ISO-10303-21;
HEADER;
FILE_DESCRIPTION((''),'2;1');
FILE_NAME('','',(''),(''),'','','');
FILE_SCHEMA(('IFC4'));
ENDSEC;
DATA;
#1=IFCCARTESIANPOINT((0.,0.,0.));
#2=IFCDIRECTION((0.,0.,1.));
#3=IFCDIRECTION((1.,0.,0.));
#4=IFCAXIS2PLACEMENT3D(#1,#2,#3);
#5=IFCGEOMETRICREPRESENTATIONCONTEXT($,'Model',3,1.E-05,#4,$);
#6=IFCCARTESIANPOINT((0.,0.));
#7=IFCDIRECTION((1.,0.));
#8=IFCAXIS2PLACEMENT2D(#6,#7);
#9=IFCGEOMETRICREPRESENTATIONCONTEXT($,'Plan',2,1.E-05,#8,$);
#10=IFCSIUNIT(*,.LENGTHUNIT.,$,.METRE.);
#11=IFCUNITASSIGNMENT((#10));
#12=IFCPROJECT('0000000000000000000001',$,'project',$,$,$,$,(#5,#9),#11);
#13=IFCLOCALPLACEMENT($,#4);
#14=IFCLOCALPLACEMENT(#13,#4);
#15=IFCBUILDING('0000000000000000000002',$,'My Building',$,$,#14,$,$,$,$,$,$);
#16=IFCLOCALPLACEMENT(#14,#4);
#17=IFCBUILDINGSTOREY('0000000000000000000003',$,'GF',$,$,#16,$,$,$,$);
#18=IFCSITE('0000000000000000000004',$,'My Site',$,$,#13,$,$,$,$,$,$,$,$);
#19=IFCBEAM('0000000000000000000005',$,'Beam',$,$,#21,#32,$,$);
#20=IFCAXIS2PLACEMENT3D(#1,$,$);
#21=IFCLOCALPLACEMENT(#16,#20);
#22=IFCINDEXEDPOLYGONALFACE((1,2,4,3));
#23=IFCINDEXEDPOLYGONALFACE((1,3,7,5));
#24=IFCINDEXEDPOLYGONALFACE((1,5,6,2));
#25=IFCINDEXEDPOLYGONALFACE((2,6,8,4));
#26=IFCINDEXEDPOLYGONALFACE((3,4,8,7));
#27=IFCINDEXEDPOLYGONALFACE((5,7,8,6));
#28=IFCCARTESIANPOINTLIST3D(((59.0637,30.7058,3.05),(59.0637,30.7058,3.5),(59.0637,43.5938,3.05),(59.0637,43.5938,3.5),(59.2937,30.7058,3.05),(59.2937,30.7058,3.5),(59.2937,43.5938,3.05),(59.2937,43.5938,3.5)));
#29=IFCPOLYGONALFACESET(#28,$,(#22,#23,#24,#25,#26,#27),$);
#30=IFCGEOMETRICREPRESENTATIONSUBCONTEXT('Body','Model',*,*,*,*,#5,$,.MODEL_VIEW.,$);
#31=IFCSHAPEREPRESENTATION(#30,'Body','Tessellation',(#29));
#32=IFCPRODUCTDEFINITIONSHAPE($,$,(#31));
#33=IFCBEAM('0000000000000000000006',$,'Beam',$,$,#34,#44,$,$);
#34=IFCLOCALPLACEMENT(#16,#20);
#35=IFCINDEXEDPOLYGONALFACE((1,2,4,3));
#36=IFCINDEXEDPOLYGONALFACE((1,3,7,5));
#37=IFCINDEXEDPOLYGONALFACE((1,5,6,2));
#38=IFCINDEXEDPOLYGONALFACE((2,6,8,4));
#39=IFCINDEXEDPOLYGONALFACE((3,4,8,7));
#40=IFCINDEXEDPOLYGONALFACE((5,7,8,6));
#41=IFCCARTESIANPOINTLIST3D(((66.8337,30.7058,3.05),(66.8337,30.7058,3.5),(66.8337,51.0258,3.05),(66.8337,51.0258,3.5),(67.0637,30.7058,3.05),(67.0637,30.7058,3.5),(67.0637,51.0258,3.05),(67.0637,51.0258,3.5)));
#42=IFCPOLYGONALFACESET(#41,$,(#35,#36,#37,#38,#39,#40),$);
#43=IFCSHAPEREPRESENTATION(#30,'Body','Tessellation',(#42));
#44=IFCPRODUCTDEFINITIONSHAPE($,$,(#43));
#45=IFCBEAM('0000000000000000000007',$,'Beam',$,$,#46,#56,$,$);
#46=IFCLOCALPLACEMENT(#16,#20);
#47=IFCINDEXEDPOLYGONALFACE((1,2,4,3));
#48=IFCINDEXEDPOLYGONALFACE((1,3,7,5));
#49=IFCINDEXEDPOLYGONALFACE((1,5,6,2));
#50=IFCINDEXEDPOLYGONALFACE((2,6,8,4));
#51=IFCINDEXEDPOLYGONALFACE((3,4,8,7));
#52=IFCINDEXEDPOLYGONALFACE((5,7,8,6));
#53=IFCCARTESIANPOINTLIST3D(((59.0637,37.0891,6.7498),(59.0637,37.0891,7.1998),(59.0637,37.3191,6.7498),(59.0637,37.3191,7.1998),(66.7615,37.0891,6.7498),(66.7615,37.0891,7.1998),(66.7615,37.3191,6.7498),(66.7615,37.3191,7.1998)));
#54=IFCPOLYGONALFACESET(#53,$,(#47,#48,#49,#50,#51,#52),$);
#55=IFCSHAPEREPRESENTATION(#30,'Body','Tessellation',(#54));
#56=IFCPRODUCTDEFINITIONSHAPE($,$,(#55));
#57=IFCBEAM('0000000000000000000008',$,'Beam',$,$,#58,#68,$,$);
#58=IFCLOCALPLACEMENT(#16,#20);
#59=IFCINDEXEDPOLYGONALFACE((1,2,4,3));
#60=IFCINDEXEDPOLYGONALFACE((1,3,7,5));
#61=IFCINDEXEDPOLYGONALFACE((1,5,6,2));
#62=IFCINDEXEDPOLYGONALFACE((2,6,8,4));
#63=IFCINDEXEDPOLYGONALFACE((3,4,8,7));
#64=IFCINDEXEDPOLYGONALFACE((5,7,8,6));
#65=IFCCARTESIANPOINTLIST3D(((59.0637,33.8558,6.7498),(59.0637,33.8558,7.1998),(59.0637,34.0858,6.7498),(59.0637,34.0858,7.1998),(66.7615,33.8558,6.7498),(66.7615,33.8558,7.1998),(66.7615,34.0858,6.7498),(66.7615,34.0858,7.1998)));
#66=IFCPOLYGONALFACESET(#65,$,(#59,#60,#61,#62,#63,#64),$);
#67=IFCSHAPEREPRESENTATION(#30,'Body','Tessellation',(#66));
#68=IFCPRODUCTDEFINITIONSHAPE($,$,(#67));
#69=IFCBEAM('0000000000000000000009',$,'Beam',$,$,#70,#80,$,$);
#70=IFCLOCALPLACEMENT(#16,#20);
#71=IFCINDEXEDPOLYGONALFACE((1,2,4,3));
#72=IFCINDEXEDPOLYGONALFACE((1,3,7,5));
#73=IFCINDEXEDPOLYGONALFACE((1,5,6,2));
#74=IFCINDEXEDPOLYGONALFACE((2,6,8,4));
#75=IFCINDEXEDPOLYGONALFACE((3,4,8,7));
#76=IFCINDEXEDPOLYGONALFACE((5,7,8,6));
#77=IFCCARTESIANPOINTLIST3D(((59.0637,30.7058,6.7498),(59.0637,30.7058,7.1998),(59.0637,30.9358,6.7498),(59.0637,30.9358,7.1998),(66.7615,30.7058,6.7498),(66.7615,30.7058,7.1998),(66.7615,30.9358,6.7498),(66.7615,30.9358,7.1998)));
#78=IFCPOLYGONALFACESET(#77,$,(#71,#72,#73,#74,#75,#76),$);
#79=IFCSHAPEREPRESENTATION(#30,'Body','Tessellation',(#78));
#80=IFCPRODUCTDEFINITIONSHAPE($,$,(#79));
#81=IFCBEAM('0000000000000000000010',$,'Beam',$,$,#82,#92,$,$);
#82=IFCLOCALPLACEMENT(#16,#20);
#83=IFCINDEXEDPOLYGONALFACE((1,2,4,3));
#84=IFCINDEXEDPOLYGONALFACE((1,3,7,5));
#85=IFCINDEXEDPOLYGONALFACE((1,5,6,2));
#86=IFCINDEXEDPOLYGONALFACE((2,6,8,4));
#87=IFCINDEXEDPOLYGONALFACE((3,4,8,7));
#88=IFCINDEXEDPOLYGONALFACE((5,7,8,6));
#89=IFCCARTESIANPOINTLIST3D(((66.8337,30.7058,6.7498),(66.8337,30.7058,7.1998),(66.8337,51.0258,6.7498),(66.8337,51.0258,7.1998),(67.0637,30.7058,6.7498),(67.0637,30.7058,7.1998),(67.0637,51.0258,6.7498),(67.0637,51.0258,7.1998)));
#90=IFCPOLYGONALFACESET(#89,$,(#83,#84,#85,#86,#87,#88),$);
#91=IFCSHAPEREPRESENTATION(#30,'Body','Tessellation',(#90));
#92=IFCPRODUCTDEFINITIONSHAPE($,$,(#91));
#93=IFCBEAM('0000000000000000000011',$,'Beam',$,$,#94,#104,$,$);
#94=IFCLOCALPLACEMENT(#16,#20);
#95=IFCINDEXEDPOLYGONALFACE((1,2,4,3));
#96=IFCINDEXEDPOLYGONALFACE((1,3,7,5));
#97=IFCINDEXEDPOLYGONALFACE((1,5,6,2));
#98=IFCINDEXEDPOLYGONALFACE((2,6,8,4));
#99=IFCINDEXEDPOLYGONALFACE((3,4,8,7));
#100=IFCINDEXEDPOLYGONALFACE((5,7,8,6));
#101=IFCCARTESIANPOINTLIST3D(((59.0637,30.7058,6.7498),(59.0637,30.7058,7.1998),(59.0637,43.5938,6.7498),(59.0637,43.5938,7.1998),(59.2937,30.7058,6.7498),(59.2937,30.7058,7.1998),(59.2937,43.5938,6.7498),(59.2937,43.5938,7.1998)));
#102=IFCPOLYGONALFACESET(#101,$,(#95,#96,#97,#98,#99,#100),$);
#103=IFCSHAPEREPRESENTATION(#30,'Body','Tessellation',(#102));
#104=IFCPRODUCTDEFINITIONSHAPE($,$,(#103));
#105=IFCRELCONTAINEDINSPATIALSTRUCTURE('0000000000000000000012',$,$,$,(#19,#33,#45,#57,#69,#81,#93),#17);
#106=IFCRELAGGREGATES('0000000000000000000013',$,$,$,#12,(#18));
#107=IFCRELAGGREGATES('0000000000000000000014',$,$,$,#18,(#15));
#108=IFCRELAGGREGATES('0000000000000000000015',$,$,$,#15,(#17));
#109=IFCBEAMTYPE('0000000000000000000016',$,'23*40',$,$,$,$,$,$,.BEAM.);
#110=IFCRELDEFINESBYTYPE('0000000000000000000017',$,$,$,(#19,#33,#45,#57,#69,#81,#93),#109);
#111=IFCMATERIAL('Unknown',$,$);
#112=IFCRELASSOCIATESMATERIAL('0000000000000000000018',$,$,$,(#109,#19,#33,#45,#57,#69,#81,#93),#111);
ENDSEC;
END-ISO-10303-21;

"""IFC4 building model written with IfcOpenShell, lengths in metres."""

from ifc_helpers import new_model, si_unit, frame, origin_with_axes, origin_2d_with_axis, place, context, subcontext, project, spatial, rectangle, extrude, material, material_profile, profile_set, profile_usage, type_object, element, save


model = new_model("IFC4")

# Units and contexts
model_context = context("Model", 3, precision=1e-05, world=origin_with_axes())
plan_context = context("Plan", 2, precision=1e-05, world=origin_2d_with_axis())
body_context = subcontext(model_context, "Body", "Model", "MODEL_VIEW")
ifc_project = project(units=[si_unit("LENGTHUNIT", "METRE")], contexts=[model_context, plan_context])

# Site, building, storey
site_placement = place(None, origin_with_axes())
site = spatial("IfcSite", under=ifc_project, at=site_placement, Name="My Site")
building_placement = place(site_placement, origin_with_axes())
building = spatial("IfcBuilding", under=site, at=building_placement, Name="My Building")
storey_placement = place(building_placement, origin_with_axes())
storey = spatial("IfcBuildingStorey", under=building, at=storey_placement, Name="GF")

# Shared definitions
ifc_material = material(Name="Unknown")

# Beams
ifc_material_profile_1 = material_profile(ifc_material, rectangle(XDim=0.23, YDim=0.45))
ifc_profile_set_1 = profile_set([ifc_material_profile_1])
beam_type = type_object("IfcBeamType", Name="23*40", PredefinedType="BEAM", material=ifc_profile_set_1)
ifc_profile_usage_1 = profile_usage(ifc_profile_set_1, cardinal=5)
beam_1_placement = place(storey_placement, frame((59.1787, 30.7058, 3.275), z_axis=(0.0, 1.0, 0.0), x_axis=(-1.0, 0.0, 0.0)))
element("IfcBeam", 1, at=beam_1_placement, inside=storey, type_object=beam_type, material=ifc_profile_usage_1, Name="Beam", context=body_context, shape_type="SweptSolid", body=[
    extrude(rectangle(XDim=0.23, YDim=0.45), origin_with_axes(), (0.0, 0.0, 1.0), 12.888),
])
ifc_profile_usage_2 = profile_usage(ifc_profile_set_1, cardinal=5)
beam_2_placement = place(storey_placement, frame((66.9487, 30.7058, 3.275), z_axis=(0.0, 1.0, 0.0), x_axis=(-1.0, 0.0, 0.0)))
element("IfcBeam", 2, at=beam_2_placement, inside=storey, type_object=beam_type, material=ifc_profile_usage_2, Name="Beam", context=body_context, shape_type="SweptSolid", body=[
    extrude(rectangle(XDim=0.23, YDim=0.45), origin_with_axes(), (0.0, 0.0, 1.0), 20.32),
])
ifc_profile_usage_3 = profile_usage(ifc_profile_set_1, cardinal=5)
beam_3_placement = place(storey_placement, frame((59.0637, 37.2041, 6.9748), z_axis=(1.0, 0.0, 0.0), x_axis=(0.0, 1.0, 0.0)))
element("IfcBeam", 3, at=beam_3_placement, inside=storey, type_object=beam_type, material=ifc_profile_usage_3, Name="Beam", context=body_context, shape_type="SweptSolid", body=[
    extrude(rectangle(XDim=0.23, YDim=0.45), origin_with_axes(), (0.0, 0.0, 1.0), 7.6978),
])
ifc_profile_usage_4 = profile_usage(ifc_profile_set_1, cardinal=5)
beam_4_placement = place(storey_placement, frame((59.0637, 33.9708, 6.9748), z_axis=(1.0, 0.0, 0.0), x_axis=(0.0, 1.0, 0.0)))
element("IfcBeam", 4, at=beam_4_placement, inside=storey, type_object=beam_type, material=ifc_profile_usage_4, Name="Beam", context=body_context, shape_type="SweptSolid", body=[
    extrude(rectangle(XDim=0.23, YDim=0.45), origin_with_axes(), (0.0, 0.0, 1.0), 7.6978),
])
ifc_profile_usage_5 = profile_usage(ifc_profile_set_1, cardinal=5)
beam_5_placement = place(storey_placement, frame((59.0637, 30.8208, 6.9748), z_axis=(1.0, 0.0, 0.0), x_axis=(0.0, 1.0, 0.0)))
element("IfcBeam", 5, at=beam_5_placement, inside=storey, type_object=beam_type, material=ifc_profile_usage_5, Name="Beam", context=body_context, shape_type="SweptSolid", body=[
    extrude(rectangle(XDim=0.23, YDim=0.45), origin_with_axes(), (0.0, 0.0, 1.0), 7.6978),
])
ifc_profile_usage_6 = profile_usage(ifc_profile_set_1, cardinal=5)
beam_6_placement = place(storey_placement, frame((66.9487, 30.7058, 6.9748), z_axis=(0.0, 1.0, 0.0), x_axis=(-1.0, 0.0, 0.0)))
element("IfcBeam", 6, at=beam_6_placement, inside=storey, type_object=beam_type, material=ifc_profile_usage_6, Name="Beam", context=body_context, shape_type="SweptSolid", body=[
    extrude(rectangle(XDim=0.23, YDim=0.45), origin_with_axes(), (0.0, 0.0, 1.0), 20.32),
])
ifc_profile_usage_7 = profile_usage(ifc_profile_set_1, cardinal=5)
beam_7_placement = place(storey_placement, frame((59.1787, 30.7058, 6.9748), z_axis=(0.0, 1.0, 0.0), x_axis=(-1.0, 0.0, 0.0)))
element("IfcBeam", 7, at=beam_7_placement, inside=storey, type_object=beam_type, material=ifc_profile_usage_7, Name="Beam", context=body_context, shape_type="SweptSolid", body=[
    extrude(rectangle(XDim=0.23, YDim=0.45), origin_with_axes(), (0.0, 0.0, 1.0), 12.888),
])

save(model, "model.ifc")
